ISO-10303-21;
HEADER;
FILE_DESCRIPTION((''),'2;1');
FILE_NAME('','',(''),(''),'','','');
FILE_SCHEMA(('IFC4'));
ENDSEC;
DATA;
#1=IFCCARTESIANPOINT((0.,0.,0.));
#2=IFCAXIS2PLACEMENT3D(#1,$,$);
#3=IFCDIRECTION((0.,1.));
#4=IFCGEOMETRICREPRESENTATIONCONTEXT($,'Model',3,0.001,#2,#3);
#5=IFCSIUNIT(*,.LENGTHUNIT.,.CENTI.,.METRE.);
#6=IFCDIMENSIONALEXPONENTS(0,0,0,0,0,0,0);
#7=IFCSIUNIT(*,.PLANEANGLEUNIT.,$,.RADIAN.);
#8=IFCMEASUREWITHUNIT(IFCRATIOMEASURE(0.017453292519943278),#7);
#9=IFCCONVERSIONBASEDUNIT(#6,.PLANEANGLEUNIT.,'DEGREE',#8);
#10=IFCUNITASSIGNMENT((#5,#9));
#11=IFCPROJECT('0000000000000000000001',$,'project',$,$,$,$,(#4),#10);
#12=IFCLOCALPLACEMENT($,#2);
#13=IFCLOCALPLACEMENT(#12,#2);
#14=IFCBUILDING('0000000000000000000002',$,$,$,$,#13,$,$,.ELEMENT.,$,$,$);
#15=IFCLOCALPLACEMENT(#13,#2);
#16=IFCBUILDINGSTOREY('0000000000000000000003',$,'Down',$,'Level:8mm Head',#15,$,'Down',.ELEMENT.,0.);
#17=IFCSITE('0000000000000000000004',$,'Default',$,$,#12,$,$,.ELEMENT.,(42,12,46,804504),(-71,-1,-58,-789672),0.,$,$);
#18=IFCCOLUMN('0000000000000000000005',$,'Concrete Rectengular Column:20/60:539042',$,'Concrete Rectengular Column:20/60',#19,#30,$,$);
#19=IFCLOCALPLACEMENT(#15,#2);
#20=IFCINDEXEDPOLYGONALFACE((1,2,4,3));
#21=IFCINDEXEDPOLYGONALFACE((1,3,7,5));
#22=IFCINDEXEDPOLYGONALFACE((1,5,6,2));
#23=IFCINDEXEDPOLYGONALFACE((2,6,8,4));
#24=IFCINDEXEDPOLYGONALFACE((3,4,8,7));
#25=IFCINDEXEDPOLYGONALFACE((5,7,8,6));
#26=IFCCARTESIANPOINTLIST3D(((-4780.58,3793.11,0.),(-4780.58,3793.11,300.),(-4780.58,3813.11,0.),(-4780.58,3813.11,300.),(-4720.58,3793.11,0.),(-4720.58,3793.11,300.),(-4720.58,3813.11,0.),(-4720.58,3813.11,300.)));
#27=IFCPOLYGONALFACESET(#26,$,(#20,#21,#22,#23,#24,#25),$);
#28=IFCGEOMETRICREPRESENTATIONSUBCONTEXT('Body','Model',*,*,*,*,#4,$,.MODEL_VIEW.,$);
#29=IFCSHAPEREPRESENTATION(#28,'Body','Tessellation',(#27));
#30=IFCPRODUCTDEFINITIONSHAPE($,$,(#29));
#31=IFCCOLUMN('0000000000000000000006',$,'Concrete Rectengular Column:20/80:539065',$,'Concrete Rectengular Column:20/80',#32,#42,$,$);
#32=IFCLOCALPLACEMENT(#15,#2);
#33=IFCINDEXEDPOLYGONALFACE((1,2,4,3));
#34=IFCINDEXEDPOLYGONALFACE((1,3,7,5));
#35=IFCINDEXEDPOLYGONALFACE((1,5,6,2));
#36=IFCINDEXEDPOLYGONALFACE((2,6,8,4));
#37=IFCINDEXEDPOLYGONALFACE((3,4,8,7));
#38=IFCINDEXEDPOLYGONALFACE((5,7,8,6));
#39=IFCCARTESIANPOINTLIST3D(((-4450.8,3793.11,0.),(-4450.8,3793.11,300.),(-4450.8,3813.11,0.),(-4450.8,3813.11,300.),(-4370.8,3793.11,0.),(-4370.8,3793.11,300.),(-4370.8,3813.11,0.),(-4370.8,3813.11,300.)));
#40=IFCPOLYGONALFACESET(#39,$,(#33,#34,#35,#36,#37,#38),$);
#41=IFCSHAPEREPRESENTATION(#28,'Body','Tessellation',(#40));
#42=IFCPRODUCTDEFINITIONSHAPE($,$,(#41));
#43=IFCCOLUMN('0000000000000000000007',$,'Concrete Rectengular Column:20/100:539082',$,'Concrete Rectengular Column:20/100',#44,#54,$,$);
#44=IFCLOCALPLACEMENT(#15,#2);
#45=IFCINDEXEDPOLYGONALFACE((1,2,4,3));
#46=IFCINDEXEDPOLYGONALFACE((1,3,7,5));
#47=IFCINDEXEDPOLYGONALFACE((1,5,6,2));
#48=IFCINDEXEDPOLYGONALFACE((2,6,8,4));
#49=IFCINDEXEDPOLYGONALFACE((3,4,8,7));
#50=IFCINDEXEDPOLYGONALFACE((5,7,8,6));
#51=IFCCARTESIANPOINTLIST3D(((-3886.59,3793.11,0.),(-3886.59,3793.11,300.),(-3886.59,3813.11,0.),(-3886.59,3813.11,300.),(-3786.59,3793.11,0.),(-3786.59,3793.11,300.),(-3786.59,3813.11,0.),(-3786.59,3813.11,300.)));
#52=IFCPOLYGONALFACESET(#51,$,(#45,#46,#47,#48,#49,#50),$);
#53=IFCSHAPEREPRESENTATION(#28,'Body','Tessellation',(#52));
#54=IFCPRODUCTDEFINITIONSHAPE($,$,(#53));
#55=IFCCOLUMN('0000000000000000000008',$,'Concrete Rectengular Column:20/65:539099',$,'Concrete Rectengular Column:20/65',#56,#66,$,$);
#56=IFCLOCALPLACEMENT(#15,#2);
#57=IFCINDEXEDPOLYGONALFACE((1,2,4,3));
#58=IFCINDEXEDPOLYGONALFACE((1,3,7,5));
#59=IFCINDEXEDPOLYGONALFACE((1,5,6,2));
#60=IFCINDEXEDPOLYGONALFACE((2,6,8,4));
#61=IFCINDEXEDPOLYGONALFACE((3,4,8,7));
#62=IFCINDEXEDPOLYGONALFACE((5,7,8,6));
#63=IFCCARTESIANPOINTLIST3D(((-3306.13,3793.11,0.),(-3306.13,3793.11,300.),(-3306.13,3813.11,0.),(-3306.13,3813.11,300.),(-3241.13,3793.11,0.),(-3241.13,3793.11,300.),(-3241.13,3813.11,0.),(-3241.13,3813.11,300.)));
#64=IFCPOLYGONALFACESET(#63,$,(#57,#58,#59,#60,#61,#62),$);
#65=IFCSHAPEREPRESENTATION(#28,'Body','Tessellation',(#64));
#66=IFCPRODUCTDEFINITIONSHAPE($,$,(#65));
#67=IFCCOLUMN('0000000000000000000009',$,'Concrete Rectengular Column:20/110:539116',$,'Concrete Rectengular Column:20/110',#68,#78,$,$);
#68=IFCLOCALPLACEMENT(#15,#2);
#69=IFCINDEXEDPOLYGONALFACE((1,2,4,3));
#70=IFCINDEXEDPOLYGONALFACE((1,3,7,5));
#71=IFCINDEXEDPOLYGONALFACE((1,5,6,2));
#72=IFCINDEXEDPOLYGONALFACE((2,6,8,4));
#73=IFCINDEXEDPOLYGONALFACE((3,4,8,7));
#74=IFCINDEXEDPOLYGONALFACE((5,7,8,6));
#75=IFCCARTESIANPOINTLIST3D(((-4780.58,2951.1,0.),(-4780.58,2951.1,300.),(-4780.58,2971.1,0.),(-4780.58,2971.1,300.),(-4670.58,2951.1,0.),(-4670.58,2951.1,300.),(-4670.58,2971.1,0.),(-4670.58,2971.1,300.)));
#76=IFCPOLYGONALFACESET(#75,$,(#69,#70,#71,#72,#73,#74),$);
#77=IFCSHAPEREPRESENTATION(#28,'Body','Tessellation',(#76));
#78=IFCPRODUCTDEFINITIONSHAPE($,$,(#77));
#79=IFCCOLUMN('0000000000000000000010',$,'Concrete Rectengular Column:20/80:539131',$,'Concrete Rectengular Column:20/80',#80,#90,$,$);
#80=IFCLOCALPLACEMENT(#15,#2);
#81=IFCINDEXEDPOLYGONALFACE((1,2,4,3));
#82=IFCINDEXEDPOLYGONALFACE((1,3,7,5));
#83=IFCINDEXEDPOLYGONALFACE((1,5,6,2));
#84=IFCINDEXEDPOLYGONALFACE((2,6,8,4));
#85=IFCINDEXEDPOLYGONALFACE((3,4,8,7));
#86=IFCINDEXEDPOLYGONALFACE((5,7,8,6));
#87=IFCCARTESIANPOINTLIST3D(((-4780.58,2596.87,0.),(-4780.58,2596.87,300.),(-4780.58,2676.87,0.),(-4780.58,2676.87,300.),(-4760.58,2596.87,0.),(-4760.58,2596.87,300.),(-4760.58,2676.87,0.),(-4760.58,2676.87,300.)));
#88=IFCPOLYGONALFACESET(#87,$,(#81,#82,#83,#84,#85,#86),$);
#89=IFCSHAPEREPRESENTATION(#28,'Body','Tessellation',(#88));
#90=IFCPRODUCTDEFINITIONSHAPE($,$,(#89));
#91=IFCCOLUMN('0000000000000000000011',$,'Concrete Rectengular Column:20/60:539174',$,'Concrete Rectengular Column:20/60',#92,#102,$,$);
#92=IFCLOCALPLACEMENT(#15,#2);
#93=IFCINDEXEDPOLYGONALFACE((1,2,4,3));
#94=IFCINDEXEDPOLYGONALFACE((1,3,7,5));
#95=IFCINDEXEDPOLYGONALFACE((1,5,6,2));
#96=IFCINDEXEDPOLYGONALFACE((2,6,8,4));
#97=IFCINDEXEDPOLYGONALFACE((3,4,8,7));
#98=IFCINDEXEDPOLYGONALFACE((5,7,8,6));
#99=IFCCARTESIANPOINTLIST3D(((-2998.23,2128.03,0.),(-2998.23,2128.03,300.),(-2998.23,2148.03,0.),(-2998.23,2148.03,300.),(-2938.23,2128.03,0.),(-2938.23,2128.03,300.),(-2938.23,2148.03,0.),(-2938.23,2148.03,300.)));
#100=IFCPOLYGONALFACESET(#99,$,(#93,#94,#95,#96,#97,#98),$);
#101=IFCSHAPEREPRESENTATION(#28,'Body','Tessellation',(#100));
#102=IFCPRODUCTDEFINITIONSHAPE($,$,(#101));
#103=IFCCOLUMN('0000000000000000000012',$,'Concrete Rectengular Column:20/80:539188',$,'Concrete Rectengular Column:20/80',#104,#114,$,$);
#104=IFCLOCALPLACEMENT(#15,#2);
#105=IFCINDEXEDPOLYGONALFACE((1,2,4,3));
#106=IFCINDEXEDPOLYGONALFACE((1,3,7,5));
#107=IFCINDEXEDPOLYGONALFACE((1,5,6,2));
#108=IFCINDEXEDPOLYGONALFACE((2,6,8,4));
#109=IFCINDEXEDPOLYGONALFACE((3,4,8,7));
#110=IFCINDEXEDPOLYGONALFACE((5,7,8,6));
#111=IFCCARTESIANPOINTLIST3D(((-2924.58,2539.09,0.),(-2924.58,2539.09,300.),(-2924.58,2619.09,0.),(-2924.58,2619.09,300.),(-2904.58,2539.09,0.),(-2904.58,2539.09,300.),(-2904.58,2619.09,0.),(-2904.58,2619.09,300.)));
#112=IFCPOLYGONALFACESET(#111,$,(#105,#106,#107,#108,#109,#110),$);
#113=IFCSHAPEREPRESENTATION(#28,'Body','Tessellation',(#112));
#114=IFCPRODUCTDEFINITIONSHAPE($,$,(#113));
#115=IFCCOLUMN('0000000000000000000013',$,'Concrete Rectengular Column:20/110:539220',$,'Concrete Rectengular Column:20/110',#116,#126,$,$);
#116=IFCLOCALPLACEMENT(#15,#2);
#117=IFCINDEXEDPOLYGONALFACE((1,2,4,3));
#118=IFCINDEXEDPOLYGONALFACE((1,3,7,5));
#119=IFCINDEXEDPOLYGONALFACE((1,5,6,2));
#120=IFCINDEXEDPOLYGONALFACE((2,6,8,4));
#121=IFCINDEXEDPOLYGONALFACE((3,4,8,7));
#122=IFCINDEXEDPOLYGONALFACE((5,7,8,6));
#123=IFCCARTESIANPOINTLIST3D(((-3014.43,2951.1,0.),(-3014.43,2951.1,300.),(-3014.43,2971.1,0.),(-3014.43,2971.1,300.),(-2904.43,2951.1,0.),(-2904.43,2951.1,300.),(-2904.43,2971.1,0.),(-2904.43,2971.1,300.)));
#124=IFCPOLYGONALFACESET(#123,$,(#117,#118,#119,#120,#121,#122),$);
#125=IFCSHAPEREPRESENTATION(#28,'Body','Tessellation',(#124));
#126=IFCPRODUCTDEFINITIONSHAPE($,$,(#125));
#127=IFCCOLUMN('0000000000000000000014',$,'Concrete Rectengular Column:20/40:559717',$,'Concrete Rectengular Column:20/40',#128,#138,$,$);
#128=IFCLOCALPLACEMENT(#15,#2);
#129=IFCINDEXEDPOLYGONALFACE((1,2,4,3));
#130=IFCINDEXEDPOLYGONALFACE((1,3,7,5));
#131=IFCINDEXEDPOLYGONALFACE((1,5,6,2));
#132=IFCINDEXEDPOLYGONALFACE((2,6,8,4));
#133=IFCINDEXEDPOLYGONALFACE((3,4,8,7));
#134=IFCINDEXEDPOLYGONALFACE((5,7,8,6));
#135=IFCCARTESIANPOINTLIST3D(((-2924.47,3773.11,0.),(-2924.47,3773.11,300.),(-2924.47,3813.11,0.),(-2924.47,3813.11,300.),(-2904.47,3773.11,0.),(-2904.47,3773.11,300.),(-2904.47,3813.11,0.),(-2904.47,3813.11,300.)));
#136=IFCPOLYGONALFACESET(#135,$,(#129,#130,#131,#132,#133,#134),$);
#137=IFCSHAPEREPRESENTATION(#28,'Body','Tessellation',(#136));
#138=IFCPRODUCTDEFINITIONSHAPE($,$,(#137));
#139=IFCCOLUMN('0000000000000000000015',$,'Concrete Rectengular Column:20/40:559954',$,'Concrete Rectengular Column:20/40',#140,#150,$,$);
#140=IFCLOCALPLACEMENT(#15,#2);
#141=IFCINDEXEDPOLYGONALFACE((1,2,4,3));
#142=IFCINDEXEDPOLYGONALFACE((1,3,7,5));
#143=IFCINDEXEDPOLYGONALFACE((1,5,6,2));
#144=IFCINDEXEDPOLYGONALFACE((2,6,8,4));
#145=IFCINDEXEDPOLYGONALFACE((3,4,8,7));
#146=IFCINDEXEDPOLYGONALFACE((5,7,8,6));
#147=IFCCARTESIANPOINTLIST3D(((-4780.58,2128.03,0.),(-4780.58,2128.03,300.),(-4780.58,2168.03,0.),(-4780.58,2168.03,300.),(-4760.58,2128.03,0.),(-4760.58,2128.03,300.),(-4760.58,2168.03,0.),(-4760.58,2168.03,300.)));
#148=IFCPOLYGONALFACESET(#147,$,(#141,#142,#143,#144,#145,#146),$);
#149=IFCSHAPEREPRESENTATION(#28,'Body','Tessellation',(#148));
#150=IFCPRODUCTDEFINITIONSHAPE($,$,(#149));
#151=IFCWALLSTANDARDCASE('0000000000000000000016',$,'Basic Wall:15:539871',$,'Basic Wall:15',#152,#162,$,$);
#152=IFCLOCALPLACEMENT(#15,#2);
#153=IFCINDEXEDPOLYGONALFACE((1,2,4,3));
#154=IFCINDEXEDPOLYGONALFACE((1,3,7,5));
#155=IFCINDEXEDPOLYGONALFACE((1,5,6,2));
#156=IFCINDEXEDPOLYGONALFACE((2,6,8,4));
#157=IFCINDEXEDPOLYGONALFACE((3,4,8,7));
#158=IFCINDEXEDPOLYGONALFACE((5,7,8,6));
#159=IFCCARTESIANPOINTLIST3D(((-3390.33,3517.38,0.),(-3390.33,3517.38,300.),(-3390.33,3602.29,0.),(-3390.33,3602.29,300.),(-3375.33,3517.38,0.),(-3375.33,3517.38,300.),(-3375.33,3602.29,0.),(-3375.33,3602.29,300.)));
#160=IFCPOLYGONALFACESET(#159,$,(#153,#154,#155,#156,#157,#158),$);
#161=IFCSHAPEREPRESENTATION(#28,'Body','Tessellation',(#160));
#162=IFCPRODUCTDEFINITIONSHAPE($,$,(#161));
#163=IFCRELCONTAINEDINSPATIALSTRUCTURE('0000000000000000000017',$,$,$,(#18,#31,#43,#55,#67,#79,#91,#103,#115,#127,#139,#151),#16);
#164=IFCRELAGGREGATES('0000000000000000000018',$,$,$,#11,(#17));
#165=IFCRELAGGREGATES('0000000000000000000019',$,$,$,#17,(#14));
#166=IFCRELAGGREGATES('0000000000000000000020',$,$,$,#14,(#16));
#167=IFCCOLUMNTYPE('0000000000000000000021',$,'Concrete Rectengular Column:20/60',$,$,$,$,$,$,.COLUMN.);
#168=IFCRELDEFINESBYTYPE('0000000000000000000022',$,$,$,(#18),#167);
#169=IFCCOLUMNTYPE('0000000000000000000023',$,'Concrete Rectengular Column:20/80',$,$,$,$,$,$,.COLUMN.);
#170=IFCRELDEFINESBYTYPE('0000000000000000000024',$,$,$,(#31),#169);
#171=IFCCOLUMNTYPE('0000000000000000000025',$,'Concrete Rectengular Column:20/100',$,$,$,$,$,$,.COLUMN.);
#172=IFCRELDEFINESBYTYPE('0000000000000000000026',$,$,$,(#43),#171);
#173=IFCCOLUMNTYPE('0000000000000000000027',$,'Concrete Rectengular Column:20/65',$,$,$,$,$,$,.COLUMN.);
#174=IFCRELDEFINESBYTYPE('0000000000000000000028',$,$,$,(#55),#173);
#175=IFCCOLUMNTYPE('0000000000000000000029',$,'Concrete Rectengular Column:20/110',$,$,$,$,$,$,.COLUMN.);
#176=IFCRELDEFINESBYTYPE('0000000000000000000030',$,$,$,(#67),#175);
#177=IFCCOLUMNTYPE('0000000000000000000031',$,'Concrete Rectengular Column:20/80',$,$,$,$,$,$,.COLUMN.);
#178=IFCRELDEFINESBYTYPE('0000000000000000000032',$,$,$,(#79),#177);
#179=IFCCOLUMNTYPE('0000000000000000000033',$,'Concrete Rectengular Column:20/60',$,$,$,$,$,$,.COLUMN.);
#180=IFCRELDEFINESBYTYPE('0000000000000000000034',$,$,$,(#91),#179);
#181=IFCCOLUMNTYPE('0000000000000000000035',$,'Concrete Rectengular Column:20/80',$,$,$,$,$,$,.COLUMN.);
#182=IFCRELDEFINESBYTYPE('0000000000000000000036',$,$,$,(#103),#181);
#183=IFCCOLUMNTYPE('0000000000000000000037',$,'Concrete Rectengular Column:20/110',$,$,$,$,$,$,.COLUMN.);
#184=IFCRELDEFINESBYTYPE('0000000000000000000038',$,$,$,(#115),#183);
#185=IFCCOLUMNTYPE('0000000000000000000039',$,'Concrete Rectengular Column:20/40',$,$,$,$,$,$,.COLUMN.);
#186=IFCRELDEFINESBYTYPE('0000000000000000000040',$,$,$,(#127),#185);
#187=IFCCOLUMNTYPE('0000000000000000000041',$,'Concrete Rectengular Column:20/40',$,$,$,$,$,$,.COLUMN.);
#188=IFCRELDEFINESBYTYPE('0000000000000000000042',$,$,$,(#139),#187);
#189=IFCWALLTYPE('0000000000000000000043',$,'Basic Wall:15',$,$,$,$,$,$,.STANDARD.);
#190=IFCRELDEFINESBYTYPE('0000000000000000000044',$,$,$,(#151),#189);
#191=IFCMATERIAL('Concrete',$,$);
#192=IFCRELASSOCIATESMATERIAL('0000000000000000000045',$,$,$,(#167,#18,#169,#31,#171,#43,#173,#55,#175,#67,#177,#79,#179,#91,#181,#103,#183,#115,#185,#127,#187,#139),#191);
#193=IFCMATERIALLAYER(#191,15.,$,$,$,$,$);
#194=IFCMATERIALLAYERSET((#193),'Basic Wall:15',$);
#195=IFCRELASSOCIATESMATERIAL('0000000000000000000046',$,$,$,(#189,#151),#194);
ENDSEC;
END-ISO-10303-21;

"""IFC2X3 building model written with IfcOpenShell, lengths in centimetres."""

from ifc_helpers import new_model, entity, si_unit, converted_unit, direction, frame, frame_2d, origin, origin_2d_with_axis, place, context, subcontext, project, spatial, rectangle, extrude, source, transform, mapped, material, layer, layer_set, layer_usage, type_object, type_shapes, element, save


model = new_model("IFC2X3")

# Units and contexts
model_context = context("Model", 3, precision=0.001, world=origin(), true_north=direction((0.0, 1.0)))
body_context = subcontext(model_context, "Body", "Model", "MODEL_VIEW")
ifc_project = project(units=[si_unit("LENGTHUNIT", "METRE", prefix="CENTI"), converted_unit("PLANEANGLEUNIT", "DEGREE", entity("IfcRatioMeasure", 0.017453292519943278), si_unit("PLANEANGLEUNIT", "RADIAN"), dimensions=[0, 0, 0, 0, 0, 0, 0])], contexts=[model_context])

# Site, building, storey
site_placement = place(None, origin())
site = spatial("IfcSite", under=ifc_project, at=site_placement, Name="Default", CompositionType="ELEMENT", RefLatitude=(42, 12, 46, 804504), RefLongitude=(-71, -1, -58, -789672), RefElevation=0.0)
building_placement = place(site_placement, origin())
building = spatial("IfcBuilding", under=site, at=building_placement, CompositionType="ELEMENT")
storey_placement = place(building_placement, origin())
storey = spatial("IfcBuildingStorey", under=building, at=storey_placement, Name="Down", ObjectType="Level:8mm Head", LongName="Down", CompositionType="ELEMENT", Elevation=0.0)

# Columns
ifc_material = material(Name="Concrete")
column_type_1 = type_object("IfcColumnType", Name="Concrete Rectengular Column:20/60", PredefinedType="COLUMN", material=ifc_material)
shared_shape_1 = source(origin(), body_context, "Body", "SweptSolid", [
    extrude(rectangle(XDim=20.0, YDim=60.0, at=frame_2d((0.0, 0.0), x_axis=(1.0, 0.0))), frame((-4750.58, 3803.11, 0.0), z_axis=(0.0, 0.0, 1.0), x_axis=(0.0, -1.0, 0.0)), (0.0, 0.0, 1.0), 300.0),
])
type_shapes(column_type_1, [shared_shape_1])
column_1_placement = place(storey_placement, origin())
element("IfcColumn", 1, at=column_1_placement, inside=storey, type_object=column_type_1, material=ifc_material, Name="Concrete Rectengular Column:20/60:539042", ObjectType="Concrete Rectengular Column:20/60", context=body_context, shape_type="MappedRepresentation", body=[
    mapped(shared_shape_1, transform((0.0, 0.0, 0.0), scale=1.0)),
])
column_type_2 = type_object("IfcColumnType", Name="Concrete Rectengular Column:20/80", PredefinedType="COLUMN", material=ifc_material)
shared_shape_2 = source(origin(), body_context, "Body", "SweptSolid", [
    extrude(rectangle(XDim=20.0, YDim=80.0, at=frame_2d((0.0, 0.0), x_axis=(1.0, 0.0))), frame((-4410.8, 3803.11, 0.0), z_axis=(0.0, 0.0, 1.0), x_axis=(0.0, -1.0, 0.0)), (0.0, 0.0, 1.0), 300.0),
])
type_shapes(column_type_2, [shared_shape_2])
column_2_placement = place(storey_placement, origin())
element("IfcColumn", 2, at=column_2_placement, inside=storey, type_object=column_type_2, material=ifc_material, Name="Concrete Rectengular Column:20/80:539065", ObjectType="Concrete Rectengular Column:20/80", context=body_context, shape_type="MappedRepresentation", body=[
    mapped(shared_shape_2, transform((0.0, 0.0, 0.0), scale=1.0)),
])
column_type_3 = type_object("IfcColumnType", Name="Concrete Rectengular Column:20/100", PredefinedType="COLUMN", material=ifc_material)
shared_shape_3 = source(origin(), body_context, "Body", "SweptSolid", [
    extrude(rectangle(XDim=20.0, YDim=100.0, at=frame_2d((0.0, 0.0), x_axis=(1.0, 0.0))), frame((-3836.59, 3803.11, 0.0), z_axis=(0.0, 0.0, 1.0), x_axis=(0.0, -1.0, 0.0)), (0.0, 0.0, 1.0), 300.0),
])
type_shapes(column_type_3, [shared_shape_3])
column_3_placement = place(storey_placement, origin())
element("IfcColumn", 3, at=column_3_placement, inside=storey, type_object=column_type_3, material=ifc_material, Name="Concrete Rectengular Column:20/100:539082", ObjectType="Concrete Rectengular Column:20/100", context=body_context, shape_type="MappedRepresentation", body=[
    mapped(shared_shape_3, transform((0.0, 0.0, 0.0), scale=1.0)),
])
column_type_4 = type_object("IfcColumnType", Name="Concrete Rectengular Column:20/65", PredefinedType="COLUMN", material=ifc_material)
shared_shape_4 = source(origin(), body_context, "Body", "SweptSolid", [
    extrude(rectangle(XDim=20.0, YDim=65.0, at=frame_2d((0.0, 0.0), x_axis=(1.0, 0.0))), frame((-3273.63, 3803.11, 0.0), z_axis=(0.0, 0.0, 1.0), x_axis=(0.0, -1.0, 0.0)), (0.0, 0.0, 1.0), 300.0),
])
type_shapes(column_type_4, [shared_shape_4])
column_4_placement = place(storey_placement, origin())
element("IfcColumn", 4, at=column_4_placement, inside=storey, type_object=column_type_4, material=ifc_material, Name="Concrete Rectengular Column:20/65:539099", ObjectType="Concrete Rectengular Column:20/65", context=body_context, shape_type="MappedRepresentation", body=[
    mapped(shared_shape_4, transform((0.0, 0.0, 0.0), scale=1.0)),
])
column_type_5 = type_object("IfcColumnType", Name="Concrete Rectengular Column:20/110", PredefinedType="COLUMN", material=ifc_material)
shared_shape_5 = source(origin(), body_context, "Body", "SweptSolid", [
    extrude(rectangle(XDim=20.0, YDim=110.0, at=origin_2d_with_axis()), frame((-4725.58, 2961.1, 0.0), z_axis=(0.0, 0.0, 1.0), x_axis=(0.0, -1.0, 0.0)), (0.0, 0.0, 1.0), 300.0),
])
type_shapes(column_type_5, [shared_shape_5])
column_5_placement = place(storey_placement, origin())
element("IfcColumn", 5, at=column_5_placement, inside=storey, type_object=column_type_5, material=ifc_material, Name="Concrete Rectengular Column:20/110:539116", ObjectType="Concrete Rectengular Column:20/110", context=body_context, shape_type="MappedRepresentation", body=[
    mapped(shared_shape_5, transform((0.0, 0.0, 0.0), scale=1.0)),
])
column_type_6 = type_object("IfcColumnType", Name="Concrete Rectengular Column:20/80", PredefinedType="COLUMN", material=ifc_material)
shared_shape_6 = source(origin(), body_context, "Body", "SweptSolid", [
    extrude(rectangle(XDim=80.0, YDim=20.0, at=frame_2d((0.0, 0.0), x_axis=(1.0, 0.0))), frame((-4770.58, 2636.87, 0.0), z_axis=(0.0, 0.0, 1.0), x_axis=(0.0, -1.0, 0.0)), (0.0, 0.0, 1.0), 300.0),
])
type_shapes(column_type_6, [shared_shape_6])
column_6_placement = place(storey_placement, origin())
element("IfcColumn", 6, at=column_6_placement, inside=storey, type_object=column_type_6, material=ifc_material, Name="Concrete Rectengular Column:20/80:539131", ObjectType="Concrete Rectengular Column:20/80", context=body_context, shape_type="MappedRepresentation", body=[
    mapped(shared_shape_6, transform((0.0, 0.0, 0.0), scale=1.0)),
])
column_type_7 = type_object("IfcColumnType", Name="Concrete Rectengular Column:20/60", PredefinedType="COLUMN", material=ifc_material)
shared_shape_7 = source(origin(), body_context, "Body", "SweptSolid", [
    extrude(rectangle(XDim=20.0, YDim=60.0, at=origin_2d_with_axis()), frame((-2968.23, 2138.03, 0.0), z_axis=(0.0, 0.0, 1.0), x_axis=(0.0, -1.0, 0.0)), (0.0, 0.0, 1.0), 300.0),
])
type_shapes(column_type_7, [shared_shape_7])
column_7_placement = place(storey_placement, origin())
element("IfcColumn", 7, at=column_7_placement, inside=storey, type_object=column_type_7, material=ifc_material, Name="Concrete Rectengular Column:20/60:539174", ObjectType="Concrete Rectengular Column:20/60", context=body_context, shape_type="MappedRepresentation", body=[
    mapped(shared_shape_7, transform((0.0, 0.0, 0.0), scale=1.0)),
])
column_type_8 = type_object("IfcColumnType", Name="Concrete Rectengular Column:20/80", PredefinedType="COLUMN", material=ifc_material)
shared_shape_8 = source(origin(), body_context, "Body", "SweptSolid", [
    extrude(rectangle(XDim=80.0, YDim=20.0, at=origin_2d_with_axis()), frame((-2914.58, 2579.09, 0.0), z_axis=(0.0, 0.0, 1.0), x_axis=(0.0, -1.0, 0.0)), (0.0, 0.0, 1.0), 300.0),
])
type_shapes(column_type_8, [shared_shape_8])
column_8_placement = place(storey_placement, origin())
element("IfcColumn", 8, at=column_8_placement, inside=storey, type_object=column_type_8, material=ifc_material, Name="Concrete Rectengular Column:20/80:539188", ObjectType="Concrete Rectengular Column:20/80", context=body_context, shape_type="MappedRepresentation", body=[
    mapped(shared_shape_8, transform((0.0, 0.0, 0.0), scale=1.0)),
])
column_type_9 = type_object("IfcColumnType", Name="Concrete Rectengular Column:20/110", PredefinedType="COLUMN", material=ifc_material)
shared_shape_9 = source(origin(), body_context, "Body", "SweptSolid", [
    extrude(rectangle(XDim=20.0, YDim=110.0, at=origin_2d_with_axis()), frame((-2959.43, 2961.1, 0.0), z_axis=(0.0, 0.0, 1.0), x_axis=(0.0, -1.0, 0.0)), (0.0, 0.0, 1.0), 300.0),
])
type_shapes(column_type_9, [shared_shape_9])
column_9_placement = place(storey_placement, origin())
element("IfcColumn", 9, at=column_9_placement, inside=storey, type_object=column_type_9, material=ifc_material, Name="Concrete Rectengular Column:20/110:539220", ObjectType="Concrete Rectengular Column:20/110", context=body_context, shape_type="MappedRepresentation", body=[
    mapped(shared_shape_9, transform((0.0, 0.0, 0.0), scale=1.0)),
])
column_type_10 = type_object("IfcColumnType", Name="Concrete Rectengular Column:20/40", PredefinedType="COLUMN", material=ifc_material)
shared_shape_10 = source(origin(), body_context, "Body", "SweptSolid", [
    extrude(rectangle(XDim=40.0, YDim=20.0, at=frame_2d((0.0, 0.0), x_axis=(1.0, 0.0))), frame((-2914.47, 3793.11, 0.0), z_axis=(0.0, 0.0, 1.0), x_axis=(0.0, -1.0, 0.0)), (0.0, 0.0, 1.0), 300.0),
])
type_shapes(column_type_10, [shared_shape_10])
column_10_placement = place(storey_placement, origin())
element("IfcColumn", 10, at=column_10_placement, inside=storey, type_object=column_type_10, material=ifc_material, Name="Concrete Rectengular Column:20/40:559717", ObjectType="Concrete Rectengular Column:20/40", context=body_context, shape_type="MappedRepresentation", body=[
    mapped(shared_shape_10, transform((0.0, 0.0, 0.0), scale=1.0)),
])
column_type_11 = type_object("IfcColumnType", Name="Concrete Rectengular Column:20/40", PredefinedType="COLUMN", material=ifc_material)
shared_shape_11 = source(origin(), body_context, "Body", "SweptSolid", [
    extrude(rectangle(XDim=40.0, YDim=20.0, at=frame_2d((0.0, 0.0), x_axis=(1.0, 0.0))), frame((-4770.58, 2148.03, 0.0), z_axis=(0.0, 0.0, 1.0), x_axis=(0.0, -1.0, 0.0)), (0.0, 0.0, 1.0), 300.0),
])
type_shapes(column_type_11, [shared_shape_11])
column_11_placement = place(storey_placement, origin())
element("IfcColumn", 11, at=column_11_placement, inside=storey, type_object=column_type_11, material=ifc_material, Name="Concrete Rectengular Column:20/40:559954", ObjectType="Concrete Rectengular Column:20/40", context=body_context, shape_type="MappedRepresentation", body=[
    mapped(shared_shape_11, transform((0.0, 0.0, 0.0), scale=1.0)),
])

# Wall
ifc_layer_1 = layer(ifc_material, 15.0)
ifc_layer_set_1 = layer_set([ifc_layer_1], Name="Basic Wall:15")
ifc_layer_usage_1 = layer_usage(ifc_layer_set_1, "AXIS2", "POSITIVE", -7.5)
wall_type_1 = type_object("IfcWallType", Name="Basic Wall:15", PredefinedType="STANDARD", material=ifc_layer_set_1)
wall_1_placement = place(storey_placement, frame((-3382.83, 3517.38, 0.0), z_axis=(0.0, 0.0, 1.0), x_axis=(0.0, 1.0, 0.0)))
element("IfcWallStandardCase", 12, at=wall_1_placement, inside=storey, type_object=wall_type_1, material=ifc_layer_usage_1, Name="Basic Wall:15:539871", ObjectType="Basic Wall:15", context=body_context, shape_type="SweptSolid", body=[
    extrude(rectangle(XDim=84.91, YDim=15.0, at=frame_2d((42.45, 0.0), x_axis=(-1.0, 0.0))), origin(), (0.0, 0.0, 1.0), 300.0),
])

save(model, "model.ifc")
